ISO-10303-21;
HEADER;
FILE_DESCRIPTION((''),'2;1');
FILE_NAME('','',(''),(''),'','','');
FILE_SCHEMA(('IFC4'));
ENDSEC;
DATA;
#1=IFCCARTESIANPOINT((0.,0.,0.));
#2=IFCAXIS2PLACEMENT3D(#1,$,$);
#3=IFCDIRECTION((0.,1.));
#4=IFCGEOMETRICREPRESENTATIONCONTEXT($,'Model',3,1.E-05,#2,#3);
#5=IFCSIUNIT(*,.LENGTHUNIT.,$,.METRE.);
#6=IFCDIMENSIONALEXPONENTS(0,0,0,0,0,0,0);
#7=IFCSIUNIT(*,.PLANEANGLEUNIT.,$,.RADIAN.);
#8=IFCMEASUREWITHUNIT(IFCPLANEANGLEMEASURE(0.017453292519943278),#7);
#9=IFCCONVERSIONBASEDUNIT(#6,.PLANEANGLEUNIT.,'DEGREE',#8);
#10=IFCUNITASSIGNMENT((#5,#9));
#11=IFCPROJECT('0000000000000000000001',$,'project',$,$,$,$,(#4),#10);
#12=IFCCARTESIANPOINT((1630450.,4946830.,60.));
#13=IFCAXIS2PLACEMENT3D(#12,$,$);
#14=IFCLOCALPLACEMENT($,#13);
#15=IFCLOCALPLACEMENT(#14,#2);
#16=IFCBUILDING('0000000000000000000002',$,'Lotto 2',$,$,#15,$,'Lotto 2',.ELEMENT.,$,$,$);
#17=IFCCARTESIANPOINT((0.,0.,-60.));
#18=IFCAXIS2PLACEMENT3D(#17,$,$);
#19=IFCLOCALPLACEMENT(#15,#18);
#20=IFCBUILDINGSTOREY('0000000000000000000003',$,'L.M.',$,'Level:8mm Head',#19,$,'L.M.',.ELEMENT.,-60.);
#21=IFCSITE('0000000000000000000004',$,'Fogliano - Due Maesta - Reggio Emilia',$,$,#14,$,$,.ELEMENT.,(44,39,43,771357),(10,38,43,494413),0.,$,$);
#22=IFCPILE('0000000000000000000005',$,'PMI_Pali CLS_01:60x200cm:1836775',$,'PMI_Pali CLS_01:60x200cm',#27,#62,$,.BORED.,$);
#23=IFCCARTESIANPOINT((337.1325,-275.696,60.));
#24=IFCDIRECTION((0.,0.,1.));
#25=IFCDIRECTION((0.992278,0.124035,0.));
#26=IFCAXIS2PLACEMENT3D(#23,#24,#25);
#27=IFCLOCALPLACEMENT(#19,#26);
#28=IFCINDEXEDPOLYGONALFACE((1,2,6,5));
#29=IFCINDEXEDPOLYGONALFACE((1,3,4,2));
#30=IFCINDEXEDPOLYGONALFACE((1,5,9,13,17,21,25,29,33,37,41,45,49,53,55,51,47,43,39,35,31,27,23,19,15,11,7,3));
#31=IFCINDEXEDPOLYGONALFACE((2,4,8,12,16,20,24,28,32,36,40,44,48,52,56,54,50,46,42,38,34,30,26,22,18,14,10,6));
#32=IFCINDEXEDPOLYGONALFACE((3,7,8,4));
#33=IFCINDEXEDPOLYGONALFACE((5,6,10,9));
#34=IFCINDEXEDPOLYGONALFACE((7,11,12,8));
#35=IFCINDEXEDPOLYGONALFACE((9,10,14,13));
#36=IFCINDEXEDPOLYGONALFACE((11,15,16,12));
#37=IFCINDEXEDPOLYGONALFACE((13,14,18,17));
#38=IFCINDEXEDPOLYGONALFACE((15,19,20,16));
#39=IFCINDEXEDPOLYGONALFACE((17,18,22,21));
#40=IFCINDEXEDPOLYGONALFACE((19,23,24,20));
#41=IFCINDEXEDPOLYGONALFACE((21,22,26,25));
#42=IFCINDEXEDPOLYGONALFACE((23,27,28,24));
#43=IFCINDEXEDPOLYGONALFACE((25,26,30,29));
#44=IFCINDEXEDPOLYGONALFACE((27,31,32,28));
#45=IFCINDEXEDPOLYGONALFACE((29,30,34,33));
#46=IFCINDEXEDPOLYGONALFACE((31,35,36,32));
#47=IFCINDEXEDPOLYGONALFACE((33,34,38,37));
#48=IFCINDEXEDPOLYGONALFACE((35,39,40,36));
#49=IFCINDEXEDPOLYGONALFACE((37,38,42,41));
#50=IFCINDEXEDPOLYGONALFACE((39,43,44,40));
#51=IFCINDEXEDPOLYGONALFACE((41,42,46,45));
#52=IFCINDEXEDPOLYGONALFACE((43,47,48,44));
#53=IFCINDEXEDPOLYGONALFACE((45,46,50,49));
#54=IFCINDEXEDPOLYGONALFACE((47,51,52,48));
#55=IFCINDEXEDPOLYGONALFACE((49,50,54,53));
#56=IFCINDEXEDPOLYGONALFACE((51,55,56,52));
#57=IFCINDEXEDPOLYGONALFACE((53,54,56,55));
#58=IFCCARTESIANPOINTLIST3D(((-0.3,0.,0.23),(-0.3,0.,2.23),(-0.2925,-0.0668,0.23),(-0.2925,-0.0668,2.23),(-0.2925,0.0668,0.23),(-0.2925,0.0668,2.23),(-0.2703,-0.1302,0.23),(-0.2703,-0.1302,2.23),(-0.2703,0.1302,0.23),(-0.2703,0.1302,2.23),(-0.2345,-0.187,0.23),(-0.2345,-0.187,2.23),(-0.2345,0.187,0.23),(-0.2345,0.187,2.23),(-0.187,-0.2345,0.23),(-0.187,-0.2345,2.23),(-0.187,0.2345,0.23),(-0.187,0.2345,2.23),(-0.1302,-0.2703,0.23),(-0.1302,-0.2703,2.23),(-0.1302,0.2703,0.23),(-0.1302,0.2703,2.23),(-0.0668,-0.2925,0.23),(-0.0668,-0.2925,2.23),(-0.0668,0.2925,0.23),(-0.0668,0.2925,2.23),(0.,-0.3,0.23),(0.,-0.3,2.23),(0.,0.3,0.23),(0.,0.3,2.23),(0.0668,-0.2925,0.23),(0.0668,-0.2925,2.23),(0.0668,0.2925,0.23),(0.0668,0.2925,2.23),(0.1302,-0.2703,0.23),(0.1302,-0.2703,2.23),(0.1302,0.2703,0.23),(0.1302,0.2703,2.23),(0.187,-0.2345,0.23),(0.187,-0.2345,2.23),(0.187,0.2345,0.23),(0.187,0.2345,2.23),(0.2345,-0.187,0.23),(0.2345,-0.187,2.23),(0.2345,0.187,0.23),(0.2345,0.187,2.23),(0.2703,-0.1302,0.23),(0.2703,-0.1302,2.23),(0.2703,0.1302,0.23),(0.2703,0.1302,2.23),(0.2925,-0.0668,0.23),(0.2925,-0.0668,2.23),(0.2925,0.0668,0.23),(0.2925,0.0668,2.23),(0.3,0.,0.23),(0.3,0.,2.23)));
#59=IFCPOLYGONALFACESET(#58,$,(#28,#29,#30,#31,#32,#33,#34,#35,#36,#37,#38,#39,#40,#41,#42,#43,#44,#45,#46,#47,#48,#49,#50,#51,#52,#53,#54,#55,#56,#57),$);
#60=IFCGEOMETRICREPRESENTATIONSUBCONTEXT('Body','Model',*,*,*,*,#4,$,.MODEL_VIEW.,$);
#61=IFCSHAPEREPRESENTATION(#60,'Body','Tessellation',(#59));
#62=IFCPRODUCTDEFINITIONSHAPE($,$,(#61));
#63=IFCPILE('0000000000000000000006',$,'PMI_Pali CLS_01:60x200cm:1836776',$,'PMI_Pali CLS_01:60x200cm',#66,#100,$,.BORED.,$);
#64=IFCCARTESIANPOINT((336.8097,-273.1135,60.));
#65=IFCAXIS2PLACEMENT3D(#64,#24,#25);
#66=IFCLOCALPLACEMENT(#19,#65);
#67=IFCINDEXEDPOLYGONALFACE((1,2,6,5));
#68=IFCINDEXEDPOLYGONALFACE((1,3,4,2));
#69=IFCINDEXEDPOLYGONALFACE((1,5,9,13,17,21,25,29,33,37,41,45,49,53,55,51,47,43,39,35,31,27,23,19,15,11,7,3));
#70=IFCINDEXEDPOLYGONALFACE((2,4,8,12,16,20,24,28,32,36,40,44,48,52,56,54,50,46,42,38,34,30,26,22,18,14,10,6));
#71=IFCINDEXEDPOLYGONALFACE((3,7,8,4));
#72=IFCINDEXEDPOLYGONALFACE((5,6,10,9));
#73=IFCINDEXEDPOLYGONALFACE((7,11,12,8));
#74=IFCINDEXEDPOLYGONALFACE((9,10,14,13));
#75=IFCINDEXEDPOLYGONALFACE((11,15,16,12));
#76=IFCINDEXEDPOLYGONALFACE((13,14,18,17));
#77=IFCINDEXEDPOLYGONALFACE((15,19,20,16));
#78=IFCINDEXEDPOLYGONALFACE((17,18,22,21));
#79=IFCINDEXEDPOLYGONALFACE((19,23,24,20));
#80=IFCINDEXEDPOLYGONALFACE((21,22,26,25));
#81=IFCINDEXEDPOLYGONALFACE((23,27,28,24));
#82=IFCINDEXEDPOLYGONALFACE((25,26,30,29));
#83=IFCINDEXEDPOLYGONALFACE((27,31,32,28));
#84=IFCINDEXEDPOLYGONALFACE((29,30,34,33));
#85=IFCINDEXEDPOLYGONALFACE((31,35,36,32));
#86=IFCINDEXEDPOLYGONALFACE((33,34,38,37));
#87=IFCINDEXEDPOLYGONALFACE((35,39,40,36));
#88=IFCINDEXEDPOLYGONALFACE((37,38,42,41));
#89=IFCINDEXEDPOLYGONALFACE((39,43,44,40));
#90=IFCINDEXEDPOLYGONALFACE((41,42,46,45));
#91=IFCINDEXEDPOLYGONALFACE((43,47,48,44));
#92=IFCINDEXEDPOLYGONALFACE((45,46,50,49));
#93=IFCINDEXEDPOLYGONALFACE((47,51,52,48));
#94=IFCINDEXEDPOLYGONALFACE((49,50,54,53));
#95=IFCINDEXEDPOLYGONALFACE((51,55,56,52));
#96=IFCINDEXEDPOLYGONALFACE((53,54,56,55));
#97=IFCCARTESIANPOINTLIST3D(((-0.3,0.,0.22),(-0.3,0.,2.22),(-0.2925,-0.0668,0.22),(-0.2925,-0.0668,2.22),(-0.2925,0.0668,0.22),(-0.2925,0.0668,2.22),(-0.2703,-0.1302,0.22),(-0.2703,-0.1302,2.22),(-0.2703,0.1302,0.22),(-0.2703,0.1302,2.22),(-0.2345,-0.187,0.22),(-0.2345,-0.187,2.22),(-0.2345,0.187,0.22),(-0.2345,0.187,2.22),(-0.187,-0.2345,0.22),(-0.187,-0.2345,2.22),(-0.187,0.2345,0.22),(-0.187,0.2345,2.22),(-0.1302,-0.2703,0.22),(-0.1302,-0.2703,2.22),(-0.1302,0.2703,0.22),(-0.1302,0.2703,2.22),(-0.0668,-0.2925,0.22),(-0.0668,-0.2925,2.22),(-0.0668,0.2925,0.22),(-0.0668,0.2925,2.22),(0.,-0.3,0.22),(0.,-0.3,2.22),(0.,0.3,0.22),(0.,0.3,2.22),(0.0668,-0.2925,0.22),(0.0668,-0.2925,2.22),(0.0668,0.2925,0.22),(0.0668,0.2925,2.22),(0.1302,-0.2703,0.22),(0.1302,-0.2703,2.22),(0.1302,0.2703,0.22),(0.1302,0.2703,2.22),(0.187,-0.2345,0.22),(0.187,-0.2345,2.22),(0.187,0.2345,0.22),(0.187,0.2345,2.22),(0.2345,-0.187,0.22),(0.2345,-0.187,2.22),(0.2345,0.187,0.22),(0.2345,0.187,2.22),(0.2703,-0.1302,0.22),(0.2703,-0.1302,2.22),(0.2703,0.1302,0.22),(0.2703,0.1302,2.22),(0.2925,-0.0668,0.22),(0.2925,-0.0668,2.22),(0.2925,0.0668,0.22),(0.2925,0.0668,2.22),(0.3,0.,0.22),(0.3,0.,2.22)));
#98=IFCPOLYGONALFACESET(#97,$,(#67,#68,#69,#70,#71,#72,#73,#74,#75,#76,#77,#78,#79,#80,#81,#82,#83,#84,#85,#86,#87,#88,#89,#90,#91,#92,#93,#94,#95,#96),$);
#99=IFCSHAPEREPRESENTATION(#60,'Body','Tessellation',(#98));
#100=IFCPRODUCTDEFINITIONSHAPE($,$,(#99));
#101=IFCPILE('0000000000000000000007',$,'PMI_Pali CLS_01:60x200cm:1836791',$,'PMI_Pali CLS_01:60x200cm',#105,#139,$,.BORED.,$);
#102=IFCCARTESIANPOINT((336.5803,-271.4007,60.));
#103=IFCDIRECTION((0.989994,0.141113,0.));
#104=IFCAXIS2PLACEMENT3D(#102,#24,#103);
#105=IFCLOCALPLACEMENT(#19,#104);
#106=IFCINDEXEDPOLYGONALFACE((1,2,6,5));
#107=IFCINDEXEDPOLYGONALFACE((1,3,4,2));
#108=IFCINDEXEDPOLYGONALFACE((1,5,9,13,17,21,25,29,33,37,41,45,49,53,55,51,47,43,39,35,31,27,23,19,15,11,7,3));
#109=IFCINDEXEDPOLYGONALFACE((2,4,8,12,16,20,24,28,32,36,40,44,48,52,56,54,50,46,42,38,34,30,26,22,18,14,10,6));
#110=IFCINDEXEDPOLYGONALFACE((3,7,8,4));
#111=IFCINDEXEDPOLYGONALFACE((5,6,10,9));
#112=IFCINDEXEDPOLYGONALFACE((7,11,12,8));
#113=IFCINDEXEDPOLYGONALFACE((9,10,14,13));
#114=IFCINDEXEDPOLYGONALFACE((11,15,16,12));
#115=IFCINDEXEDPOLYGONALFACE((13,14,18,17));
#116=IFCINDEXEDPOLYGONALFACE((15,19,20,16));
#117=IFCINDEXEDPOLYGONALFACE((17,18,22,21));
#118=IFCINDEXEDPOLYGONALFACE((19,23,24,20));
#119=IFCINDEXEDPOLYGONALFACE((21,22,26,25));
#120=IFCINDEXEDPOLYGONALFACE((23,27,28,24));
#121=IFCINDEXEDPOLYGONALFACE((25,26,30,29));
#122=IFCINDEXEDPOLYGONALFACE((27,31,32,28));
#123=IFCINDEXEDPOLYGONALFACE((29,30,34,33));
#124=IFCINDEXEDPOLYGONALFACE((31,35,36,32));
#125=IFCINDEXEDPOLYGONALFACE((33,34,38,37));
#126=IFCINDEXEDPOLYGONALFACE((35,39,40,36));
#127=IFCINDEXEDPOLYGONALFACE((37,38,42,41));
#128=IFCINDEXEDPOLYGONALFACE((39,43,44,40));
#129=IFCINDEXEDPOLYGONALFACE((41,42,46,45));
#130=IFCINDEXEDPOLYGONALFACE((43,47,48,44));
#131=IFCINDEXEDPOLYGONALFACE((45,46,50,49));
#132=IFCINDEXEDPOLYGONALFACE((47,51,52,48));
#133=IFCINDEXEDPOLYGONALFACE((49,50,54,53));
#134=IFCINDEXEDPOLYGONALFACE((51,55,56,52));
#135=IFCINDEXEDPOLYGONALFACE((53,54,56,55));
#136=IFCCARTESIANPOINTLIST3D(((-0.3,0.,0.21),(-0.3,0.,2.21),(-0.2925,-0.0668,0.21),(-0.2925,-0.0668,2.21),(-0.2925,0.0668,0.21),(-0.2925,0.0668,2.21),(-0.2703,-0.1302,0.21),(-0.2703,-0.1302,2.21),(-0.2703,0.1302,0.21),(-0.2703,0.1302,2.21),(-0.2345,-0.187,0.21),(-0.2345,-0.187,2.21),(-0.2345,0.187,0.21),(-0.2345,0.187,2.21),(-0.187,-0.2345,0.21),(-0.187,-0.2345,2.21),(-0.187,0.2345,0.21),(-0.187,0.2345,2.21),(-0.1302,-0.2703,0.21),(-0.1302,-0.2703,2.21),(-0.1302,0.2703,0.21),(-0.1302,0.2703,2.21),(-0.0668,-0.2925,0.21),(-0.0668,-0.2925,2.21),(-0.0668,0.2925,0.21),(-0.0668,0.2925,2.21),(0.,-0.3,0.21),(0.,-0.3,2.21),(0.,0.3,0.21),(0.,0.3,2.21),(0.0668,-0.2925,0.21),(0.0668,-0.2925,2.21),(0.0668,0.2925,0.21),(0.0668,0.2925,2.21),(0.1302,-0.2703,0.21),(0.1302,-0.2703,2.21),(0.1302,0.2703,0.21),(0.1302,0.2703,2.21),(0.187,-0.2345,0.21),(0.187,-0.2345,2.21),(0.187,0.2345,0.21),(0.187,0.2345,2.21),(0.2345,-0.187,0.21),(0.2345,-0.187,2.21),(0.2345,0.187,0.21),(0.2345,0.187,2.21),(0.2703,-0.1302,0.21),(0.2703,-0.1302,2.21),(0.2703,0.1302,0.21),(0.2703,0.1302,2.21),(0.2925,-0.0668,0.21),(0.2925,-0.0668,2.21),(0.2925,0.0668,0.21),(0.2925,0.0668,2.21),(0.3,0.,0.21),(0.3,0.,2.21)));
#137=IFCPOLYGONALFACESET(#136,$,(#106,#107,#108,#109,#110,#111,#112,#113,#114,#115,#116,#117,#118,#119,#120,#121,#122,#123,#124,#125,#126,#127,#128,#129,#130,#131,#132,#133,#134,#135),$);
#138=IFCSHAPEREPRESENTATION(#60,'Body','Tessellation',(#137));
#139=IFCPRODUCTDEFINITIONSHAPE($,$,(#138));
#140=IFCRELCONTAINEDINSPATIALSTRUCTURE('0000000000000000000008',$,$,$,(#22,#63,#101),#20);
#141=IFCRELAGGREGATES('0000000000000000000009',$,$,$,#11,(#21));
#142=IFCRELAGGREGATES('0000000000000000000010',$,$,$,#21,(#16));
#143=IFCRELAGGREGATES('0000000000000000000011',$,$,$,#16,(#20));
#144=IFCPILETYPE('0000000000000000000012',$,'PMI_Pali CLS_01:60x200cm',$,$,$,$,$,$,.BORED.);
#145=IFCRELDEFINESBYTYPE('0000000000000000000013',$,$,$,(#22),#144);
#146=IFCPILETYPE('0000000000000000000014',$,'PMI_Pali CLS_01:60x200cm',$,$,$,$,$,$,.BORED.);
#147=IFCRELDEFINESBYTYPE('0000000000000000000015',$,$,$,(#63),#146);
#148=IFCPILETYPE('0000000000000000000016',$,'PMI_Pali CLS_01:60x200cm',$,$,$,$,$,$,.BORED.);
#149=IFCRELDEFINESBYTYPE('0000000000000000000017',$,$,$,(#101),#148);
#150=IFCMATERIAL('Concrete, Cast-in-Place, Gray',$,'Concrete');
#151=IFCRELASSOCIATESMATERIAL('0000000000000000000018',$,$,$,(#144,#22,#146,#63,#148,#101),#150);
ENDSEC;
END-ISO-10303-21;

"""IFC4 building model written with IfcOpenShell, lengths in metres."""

from ifc_helpers import new_model, entity, si_unit, converted_unit, direction, frame, origin, place, context, subcontext, project, spatial, arc, indexed_curve, outline, extrude, source, transform, mapped, material, type_object, type_shapes, element, save


model = new_model("IFC4")

# Units and contexts
model_context = context("Model", 3, precision=1e-05, world=origin(), true_north=direction((0.0, 1.0)))
body_context = subcontext(model_context, "Body", "Model", "MODEL_VIEW")
ifc_project = project(units=[si_unit("LENGTHUNIT", "METRE"), converted_unit("PLANEANGLEUNIT", "DEGREE", entity("IfcPlaneAngleMeasure", 0.017453292519943278), si_unit("PLANEANGLEUNIT", "RADIAN"), dimensions=[0, 0, 0, 0, 0, 0, 0])], contexts=[model_context])

# Site, building, storey
site_placement = place(None, frame((1630450.0, 4946830.0, 60.0)))
site = spatial("IfcSite", under=ifc_project, at=site_placement, Name="Fogliano - Due Maesta - Reggio Emilia", CompositionType="ELEMENT", RefLatitude=(44, 39, 43, 771357), RefLongitude=(10, 38, 43, 494413), RefElevation=0.0)
building_placement = place(site_placement, origin())
building = spatial("IfcBuilding", under=site, at=building_placement, Name="Lotto 2", LongName="Lotto 2", CompositionType="ELEMENT")
storey_placement = place(building_placement, frame((0.0, 0.0, -60.0)))
storey = spatial("IfcBuildingStorey", under=building, at=storey_placement, Name="L.M.", ObjectType="Level:8mm Head", LongName="L.M.", CompositionType="ELEMENT", Elevation=-60.0)

# Piles
ifc_material_1 = material(Name="Concrete, Cast-in-Place, Gray", Category="Concrete")
pile_type_1 = type_object("IfcPileType", Name="PMI_Pali CLS_01:60x200cm", PredefinedType="BORED", material=ifc_material_1)
shared_shape_1 = source(origin(), body_context, "Body", "SweptSolid", [
    extrude(outline(indexed_curve([(-0.3, 0.0), (0.0, -0.3), (0.3, 0.0), (0.0, 0.3)], segments=[arc(1, 2, 3), arc(3, 4, 1)], self_intersect=False)), frame((0.0, 0.0, 0.23)), (0.0, 0.0, 1.0), 2.0),
])
type_shapes(pile_type_1, [shared_shape_1])
pile_1_placement = place(storey_placement, frame((337.1325, -275.696, 60.0), z_axis=(0.0, 0.0, 1.0), x_axis=(0.992278, 0.124035, 0.0)))
element("IfcPile", 1, at=pile_1_placement, inside=storey, type_object=pile_type_1, material=ifc_material_1, Name="PMI_Pali CLS_01:60x200cm:1836775", ObjectType="PMI_Pali CLS_01:60x200cm", PredefinedType="BORED", context=body_context, shape_type="MappedRepresentation", body=[
    mapped(shared_shape_1, transform((0.0, 0.0, 0.0), scale=1.0)),
])
pile_type_2 = type_object("IfcPileType", Name="PMI_Pali CLS_01:60x200cm", PredefinedType="BORED", material=ifc_material_1)
shared_shape_2 = source(origin(), body_context, "Body", "SweptSolid", [
    extrude(outline(indexed_curve([(-0.3, 0.0), (0.0, -0.3), (0.3, 0.0), (0.0, 0.3)], segments=[arc(1, 2, 3), arc(3, 4, 1)], self_intersect=False)), frame((0.0, 0.0, 0.22)), (0.0, 0.0, 1.0), 2.0),
])
type_shapes(pile_type_2, [shared_shape_2])
pile_2_placement = place(storey_placement, frame((336.8097, -273.1135, 60.0), z_axis=(0.0, 0.0, 1.0), x_axis=(0.992278, 0.124035, 0.0)))
element("IfcPile", 2, at=pile_2_placement, inside=storey, type_object=pile_type_2, material=ifc_material_1, Name="PMI_Pali CLS_01:60x200cm:1836776", ObjectType="PMI_Pali CLS_01:60x200cm", PredefinedType="BORED", context=body_context, shape_type="MappedRepresentation", body=[
    mapped(shared_shape_2, transform((0.0, 0.0, 0.0), scale=1.0)),
])
pile_type_3 = type_object("IfcPileType", Name="PMI_Pali CLS_01:60x200cm", PredefinedType="BORED", material=ifc_material_1)
shared_shape_3 = source(origin(), body_context, "Body", "SweptSolid", [
    extrude(outline(indexed_curve([(-0.3, 0.0), (0.0, -0.3), (0.3, 0.0), (0.0, 0.3)], segments=[arc(1, 2, 3), arc(3, 4, 1)], self_intersect=False)), frame((0.0, 0.0, 0.21)), (0.0, 0.0, 1.0), 2.0),
])
type_shapes(pile_type_3, [shared_shape_3])
pile_3_placement = place(storey_placement, frame((336.5803, -271.4007, 60.0), z_axis=(0.0, 0.0, 1.0), x_axis=(0.989994, 0.141113, 0.0)))
element("IfcPile", 3, at=pile_3_placement, inside=storey, type_object=pile_type_3, material=ifc_material_1, Name="PMI_Pali CLS_01:60x200cm:1836791", ObjectType="PMI_Pali CLS_01:60x200cm", PredefinedType="BORED", context=body_context, shape_type="MappedRepresentation", body=[
    mapped(shared_shape_3, transform((0.0, 0.0, 0.0), scale=1.0)),
])

save(model, "model.ifc")
